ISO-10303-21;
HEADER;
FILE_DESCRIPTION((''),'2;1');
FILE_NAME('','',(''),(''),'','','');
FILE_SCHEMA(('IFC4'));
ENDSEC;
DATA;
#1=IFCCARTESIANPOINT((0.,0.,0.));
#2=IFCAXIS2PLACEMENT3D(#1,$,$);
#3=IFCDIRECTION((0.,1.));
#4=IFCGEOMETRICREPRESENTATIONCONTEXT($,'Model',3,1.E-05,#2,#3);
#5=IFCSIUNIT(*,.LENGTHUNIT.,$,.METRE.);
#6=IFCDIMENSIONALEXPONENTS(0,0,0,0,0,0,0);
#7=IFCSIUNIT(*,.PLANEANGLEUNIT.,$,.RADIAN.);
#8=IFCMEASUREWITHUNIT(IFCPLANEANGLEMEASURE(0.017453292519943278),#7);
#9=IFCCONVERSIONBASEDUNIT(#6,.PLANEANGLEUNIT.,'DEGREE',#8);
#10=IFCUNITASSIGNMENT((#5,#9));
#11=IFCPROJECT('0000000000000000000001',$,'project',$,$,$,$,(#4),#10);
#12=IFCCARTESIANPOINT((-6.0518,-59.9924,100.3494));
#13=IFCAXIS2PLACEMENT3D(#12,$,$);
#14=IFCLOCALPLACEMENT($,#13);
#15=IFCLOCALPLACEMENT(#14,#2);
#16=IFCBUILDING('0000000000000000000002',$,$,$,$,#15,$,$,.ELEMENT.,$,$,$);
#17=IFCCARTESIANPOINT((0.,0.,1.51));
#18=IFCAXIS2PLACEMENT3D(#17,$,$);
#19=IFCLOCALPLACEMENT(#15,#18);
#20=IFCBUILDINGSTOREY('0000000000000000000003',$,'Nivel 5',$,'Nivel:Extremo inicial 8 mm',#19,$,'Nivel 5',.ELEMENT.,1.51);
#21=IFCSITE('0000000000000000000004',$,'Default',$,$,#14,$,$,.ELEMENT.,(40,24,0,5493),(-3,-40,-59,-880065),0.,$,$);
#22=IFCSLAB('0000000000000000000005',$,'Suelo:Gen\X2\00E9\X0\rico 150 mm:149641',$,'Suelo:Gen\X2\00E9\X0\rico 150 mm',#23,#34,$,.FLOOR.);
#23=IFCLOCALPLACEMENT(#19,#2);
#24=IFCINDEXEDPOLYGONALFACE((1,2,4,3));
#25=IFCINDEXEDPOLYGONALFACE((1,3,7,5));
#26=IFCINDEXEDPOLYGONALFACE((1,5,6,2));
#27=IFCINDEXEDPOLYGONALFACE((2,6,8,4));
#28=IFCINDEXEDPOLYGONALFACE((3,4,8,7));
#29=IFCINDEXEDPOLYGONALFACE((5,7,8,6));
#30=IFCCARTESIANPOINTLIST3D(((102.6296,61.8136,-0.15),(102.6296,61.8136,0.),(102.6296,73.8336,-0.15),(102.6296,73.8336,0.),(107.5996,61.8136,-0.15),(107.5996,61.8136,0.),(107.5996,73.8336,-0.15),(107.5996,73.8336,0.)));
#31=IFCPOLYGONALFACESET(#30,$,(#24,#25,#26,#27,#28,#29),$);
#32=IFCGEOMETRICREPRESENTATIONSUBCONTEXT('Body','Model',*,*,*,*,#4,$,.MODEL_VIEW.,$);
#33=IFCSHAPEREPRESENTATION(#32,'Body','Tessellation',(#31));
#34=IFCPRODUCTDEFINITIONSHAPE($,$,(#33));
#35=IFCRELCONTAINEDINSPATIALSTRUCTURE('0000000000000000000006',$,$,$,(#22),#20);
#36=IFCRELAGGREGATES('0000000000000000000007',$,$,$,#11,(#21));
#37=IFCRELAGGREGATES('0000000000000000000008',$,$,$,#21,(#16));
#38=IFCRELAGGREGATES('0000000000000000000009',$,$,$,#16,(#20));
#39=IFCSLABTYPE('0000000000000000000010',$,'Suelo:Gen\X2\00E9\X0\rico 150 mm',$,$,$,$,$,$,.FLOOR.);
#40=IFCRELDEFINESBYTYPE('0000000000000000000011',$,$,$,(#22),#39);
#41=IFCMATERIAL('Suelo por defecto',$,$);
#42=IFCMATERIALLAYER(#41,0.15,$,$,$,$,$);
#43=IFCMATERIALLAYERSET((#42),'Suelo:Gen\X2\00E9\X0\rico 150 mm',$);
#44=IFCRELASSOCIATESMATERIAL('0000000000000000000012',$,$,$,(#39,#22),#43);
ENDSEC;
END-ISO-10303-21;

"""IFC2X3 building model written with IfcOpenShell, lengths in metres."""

from ifc_helpers import new_model, entity, si_unit, converted_unit, direction, frame, frame_2d, origin, place, context, subcontext, project, spatial, rectangle, extrude, material, layer, layer_set, layer_usage, type_object, element, save


model = new_model("IFC2X3")

# Units and contexts
model_context = context("Model", 3, precision=1e-05, world=origin(), true_north=direction((0.0, 1.0)))
body_context = subcontext(model_context, "Body", "Model", "MODEL_VIEW")
ifc_project = project(units=[si_unit("LENGTHUNIT", "METRE"), converted_unit("PLANEANGLEUNIT", "DEGREE", entity("IfcPlaneAngleMeasure", 0.017453292519943278), si_unit("PLANEANGLEUNIT", "RADIAN"), dimensions=[0, 0, 0, 0, 0, 0, 0])], contexts=[model_context])

# Site, building, storey
site_placement = place(None, frame((-6.0518, -59.9924, 100.3494)))
site = spatial("IfcSite", under=ifc_project, at=site_placement, Name="Default", CompositionType="ELEMENT", RefLatitude=(40, 24, 0, 5493), RefLongitude=(-3, -40, -59, -880065), RefElevation=0.0)
building_placement = place(site_placement, origin())
building = spatial("IfcBuilding", under=site, at=building_placement, CompositionType="ELEMENT")
storey_placement = place(building_placement, frame((0.0, 0.0, 1.51)))
storey = spatial("IfcBuildingStorey", under=building, at=storey_placement, Name="Nivel 5", ObjectType="Nivel:Extremo inicial 8 mm", LongName="Nivel 5", CompositionType="ELEMENT", Elevation=1.51)

# Slab
ifc_material_1 = material(Name="Suelo por defecto")
ifc_layer = layer(ifc_material_1, 0.15)
ifc_layer_set = layer_set([ifc_layer], Name="Suelo:Genérico 150 mm")
ifc_layer_usage = layer_usage(ifc_layer_set, "AXIS3", "POSITIVE", 0.0)
slab_type = type_object("IfcSlabType", Name="Suelo:Genérico 150 mm", PredefinedType="FLOOR", material=ifc_layer_set)
slab_placement = place(storey_placement, origin())
element("IfcSlab", 1, at=slab_placement, inside=storey, type_object=slab_type, material=ifc_layer_usage, Name="Suelo:Genérico 150 mm:149641", ObjectType="Suelo:Genérico 150 mm", PredefinedType="FLOOR", context=body_context, shape_type="SweptSolid", body=[
    extrude(rectangle(XDim=12.02, YDim=4.97, at=frame_2d((0.0, 0.0), x_axis=(1.0, 0.0))), frame((105.1146, 67.8236, 0.0), z_axis=(0.0, 0.0, -1.0), x_axis=(0.0, 1.0, 0.0)), (0.0, 0.0, 1.0), 0.15),
])

save(model, "model.ifc")
